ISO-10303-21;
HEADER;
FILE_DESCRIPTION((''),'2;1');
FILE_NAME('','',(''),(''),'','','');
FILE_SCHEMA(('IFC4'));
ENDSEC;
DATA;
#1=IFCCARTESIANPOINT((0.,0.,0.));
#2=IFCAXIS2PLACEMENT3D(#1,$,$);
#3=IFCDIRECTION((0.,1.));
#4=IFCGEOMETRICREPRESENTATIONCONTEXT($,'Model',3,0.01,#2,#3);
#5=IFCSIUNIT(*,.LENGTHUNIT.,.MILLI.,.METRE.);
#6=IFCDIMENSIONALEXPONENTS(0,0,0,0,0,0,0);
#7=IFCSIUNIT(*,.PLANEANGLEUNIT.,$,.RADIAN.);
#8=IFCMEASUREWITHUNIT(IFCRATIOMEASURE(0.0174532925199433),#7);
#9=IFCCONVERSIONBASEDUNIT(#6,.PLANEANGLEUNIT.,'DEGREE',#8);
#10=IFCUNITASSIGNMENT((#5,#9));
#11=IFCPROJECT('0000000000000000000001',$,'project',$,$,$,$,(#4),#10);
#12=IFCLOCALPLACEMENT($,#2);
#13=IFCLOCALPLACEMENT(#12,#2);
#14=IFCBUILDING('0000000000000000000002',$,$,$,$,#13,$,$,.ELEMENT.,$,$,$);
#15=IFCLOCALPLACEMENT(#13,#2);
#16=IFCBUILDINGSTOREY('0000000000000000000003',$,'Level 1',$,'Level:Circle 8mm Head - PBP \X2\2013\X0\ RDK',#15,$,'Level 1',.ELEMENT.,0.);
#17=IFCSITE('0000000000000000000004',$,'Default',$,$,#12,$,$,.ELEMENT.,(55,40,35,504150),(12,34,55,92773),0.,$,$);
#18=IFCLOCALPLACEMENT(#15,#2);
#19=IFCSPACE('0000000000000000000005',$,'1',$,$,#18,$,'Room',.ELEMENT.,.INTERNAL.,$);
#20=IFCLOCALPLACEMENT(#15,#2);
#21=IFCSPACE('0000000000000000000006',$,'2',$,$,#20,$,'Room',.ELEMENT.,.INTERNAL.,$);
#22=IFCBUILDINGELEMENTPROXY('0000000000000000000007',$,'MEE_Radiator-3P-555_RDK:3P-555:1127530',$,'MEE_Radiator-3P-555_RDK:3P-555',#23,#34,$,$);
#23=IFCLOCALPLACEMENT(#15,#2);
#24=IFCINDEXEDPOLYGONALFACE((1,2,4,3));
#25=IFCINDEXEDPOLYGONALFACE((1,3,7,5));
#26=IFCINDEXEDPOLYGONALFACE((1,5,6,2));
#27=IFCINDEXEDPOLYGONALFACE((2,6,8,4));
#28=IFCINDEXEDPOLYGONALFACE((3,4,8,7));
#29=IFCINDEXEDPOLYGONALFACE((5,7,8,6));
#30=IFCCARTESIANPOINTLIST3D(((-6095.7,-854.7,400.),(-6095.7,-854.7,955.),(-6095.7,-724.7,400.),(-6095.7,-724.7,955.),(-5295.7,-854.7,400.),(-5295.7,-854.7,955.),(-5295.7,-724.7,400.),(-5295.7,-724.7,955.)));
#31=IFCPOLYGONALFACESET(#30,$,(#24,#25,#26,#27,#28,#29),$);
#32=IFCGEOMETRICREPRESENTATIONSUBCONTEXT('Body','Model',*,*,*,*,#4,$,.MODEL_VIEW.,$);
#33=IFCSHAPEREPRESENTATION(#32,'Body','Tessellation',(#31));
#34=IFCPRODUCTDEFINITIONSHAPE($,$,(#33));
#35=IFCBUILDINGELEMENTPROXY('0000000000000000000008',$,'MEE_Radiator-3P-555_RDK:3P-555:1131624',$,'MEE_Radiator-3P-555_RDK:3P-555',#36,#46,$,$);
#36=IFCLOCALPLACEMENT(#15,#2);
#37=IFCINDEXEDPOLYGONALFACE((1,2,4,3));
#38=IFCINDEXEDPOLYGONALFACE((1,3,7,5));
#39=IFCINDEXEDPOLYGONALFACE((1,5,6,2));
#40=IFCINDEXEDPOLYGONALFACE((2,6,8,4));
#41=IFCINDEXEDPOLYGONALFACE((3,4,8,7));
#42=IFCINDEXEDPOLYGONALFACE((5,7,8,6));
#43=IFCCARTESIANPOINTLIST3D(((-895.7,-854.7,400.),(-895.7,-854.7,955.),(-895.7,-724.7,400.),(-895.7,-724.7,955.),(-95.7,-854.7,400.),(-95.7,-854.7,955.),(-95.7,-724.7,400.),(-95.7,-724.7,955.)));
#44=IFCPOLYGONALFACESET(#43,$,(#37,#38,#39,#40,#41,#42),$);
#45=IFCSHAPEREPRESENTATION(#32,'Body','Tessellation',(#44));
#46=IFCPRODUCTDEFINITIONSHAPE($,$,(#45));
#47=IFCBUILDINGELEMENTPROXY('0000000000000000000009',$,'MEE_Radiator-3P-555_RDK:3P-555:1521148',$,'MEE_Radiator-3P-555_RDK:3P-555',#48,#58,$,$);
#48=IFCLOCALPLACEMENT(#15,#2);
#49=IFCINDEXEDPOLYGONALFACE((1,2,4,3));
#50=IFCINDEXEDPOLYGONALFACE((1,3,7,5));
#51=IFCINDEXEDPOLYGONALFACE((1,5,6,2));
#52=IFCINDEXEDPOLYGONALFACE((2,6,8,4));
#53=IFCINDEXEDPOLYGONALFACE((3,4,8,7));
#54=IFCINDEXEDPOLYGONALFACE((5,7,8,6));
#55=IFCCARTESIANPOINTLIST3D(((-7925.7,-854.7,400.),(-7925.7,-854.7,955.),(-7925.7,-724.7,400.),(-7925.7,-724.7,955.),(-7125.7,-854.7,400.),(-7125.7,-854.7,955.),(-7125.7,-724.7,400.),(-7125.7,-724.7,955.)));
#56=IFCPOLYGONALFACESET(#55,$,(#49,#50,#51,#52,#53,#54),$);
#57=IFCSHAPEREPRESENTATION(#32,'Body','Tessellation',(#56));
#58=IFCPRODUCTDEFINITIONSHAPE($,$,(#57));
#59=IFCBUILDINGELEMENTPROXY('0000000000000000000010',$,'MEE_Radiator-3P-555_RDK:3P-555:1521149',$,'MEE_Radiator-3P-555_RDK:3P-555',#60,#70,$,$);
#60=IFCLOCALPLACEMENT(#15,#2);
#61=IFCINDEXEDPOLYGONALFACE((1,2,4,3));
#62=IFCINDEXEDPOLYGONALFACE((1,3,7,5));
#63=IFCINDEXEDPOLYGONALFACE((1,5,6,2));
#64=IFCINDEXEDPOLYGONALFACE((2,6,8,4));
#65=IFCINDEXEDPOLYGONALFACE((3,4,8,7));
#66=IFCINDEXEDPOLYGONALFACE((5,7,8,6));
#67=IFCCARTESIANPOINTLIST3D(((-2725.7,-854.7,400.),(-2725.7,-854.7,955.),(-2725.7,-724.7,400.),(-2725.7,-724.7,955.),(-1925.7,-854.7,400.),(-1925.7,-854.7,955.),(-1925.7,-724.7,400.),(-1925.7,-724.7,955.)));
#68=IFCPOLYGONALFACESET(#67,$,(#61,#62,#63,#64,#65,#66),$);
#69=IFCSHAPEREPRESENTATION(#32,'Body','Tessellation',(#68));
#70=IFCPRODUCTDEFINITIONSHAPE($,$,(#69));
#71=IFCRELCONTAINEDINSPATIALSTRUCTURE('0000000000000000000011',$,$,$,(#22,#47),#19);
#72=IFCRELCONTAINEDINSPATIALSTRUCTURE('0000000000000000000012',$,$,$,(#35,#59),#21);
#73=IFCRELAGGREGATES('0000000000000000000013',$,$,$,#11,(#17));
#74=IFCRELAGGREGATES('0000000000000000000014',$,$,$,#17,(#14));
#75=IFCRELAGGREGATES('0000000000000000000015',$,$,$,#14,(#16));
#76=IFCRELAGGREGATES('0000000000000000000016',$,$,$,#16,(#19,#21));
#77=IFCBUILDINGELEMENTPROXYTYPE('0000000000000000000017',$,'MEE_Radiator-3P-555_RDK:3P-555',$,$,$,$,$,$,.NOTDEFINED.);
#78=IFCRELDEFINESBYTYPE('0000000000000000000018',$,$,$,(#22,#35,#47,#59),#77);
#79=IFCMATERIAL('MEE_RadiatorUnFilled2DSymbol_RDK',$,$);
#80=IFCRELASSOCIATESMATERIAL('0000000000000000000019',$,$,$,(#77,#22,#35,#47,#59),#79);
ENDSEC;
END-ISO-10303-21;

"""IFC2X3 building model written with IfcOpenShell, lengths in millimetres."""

from ifc_helpers import new_model, entity, si_unit, converted_unit, direction, frame, origin, origin_2d_with_axis, place, context, subcontext, project, spatial, rectangle, extrude, source, transform, mapped, material, type_object, type_shapes, element, save


model = new_model("IFC2X3")

# Units and contexts
model_context = context("Model", 3, precision=0.01, world=origin(), true_north=direction((0.0, 1.0)))
body_context = subcontext(model_context, "Body", "Model", "MODEL_VIEW")
ifc_project = project(units=[si_unit("LENGTHUNIT", "METRE", prefix="MILLI"), converted_unit("PLANEANGLEUNIT", "DEGREE", entity("IfcRatioMeasure", 0.0174532925199433), si_unit("PLANEANGLEUNIT", "RADIAN"), dimensions=[0, 0, 0, 0, 0, 0, 0])], contexts=[model_context])

# Site, building, storey
site_placement = place(None, origin())
site = spatial("IfcSite", under=ifc_project, at=site_placement, Name="Default", CompositionType="ELEMENT", RefLatitude=(55, 40, 35, 504150), RefLongitude=(12, 34, 55, 92773), RefElevation=0.0)
building_placement = place(site_placement, origin())
building = spatial("IfcBuilding", under=site, at=building_placement, CompositionType="ELEMENT")
storey_placement = place(building_placement, origin())
storey = spatial("IfcBuildingStorey", under=building, at=storey_placement, Name="Level 1", ObjectType="Level:Circle 8mm Head - PBP – RDK", LongName="Level 1", CompositionType="ELEMENT", Elevation=0.0)

# Shared definitions
space_1_placement = place(storey_placement, origin())
space_1 = spatial("IfcSpace", under=storey, at=space_1_placement, Name="1", LongName="Room", CompositionType="ELEMENT", InteriorOrExteriorSpace="INTERNAL")

# Building element proxy
ifc_material_1 = material(Name="MEE_RadiatorUnFilled2DSymbol_RDK")
building_element_proxy_type_1 = type_object("IfcBuildingElementProxyType", Name="MEE_Radiator-3P-555_RDK:3P-555", PredefinedType="NOTDEFINED", material=ifc_material_1)
shared_shape_1 = source(origin(), body_context, "Body", "SweptSolid", [
    extrude(rectangle(XDim=800.0, YDim=130.0, at=origin_2d_with_axis()), frame((0.0, -65.0, 0.0), z_axis=(0.0, 0.0, 1.0), x_axis=(-1.0, 0.0, 0.0)), (0.0, 0.0, 1.0), 555.0),
])
type_shapes(building_element_proxy_type_1, [shared_shape_1])
proxy_1_placement = place(space_1_placement, frame((-5695.7, -854.7, 400.0), z_axis=(0.0, 0.0, 1.0), x_axis=(-1.0, 0.0, 0.0)))
element("IfcBuildingElementProxy", 1, at=proxy_1_placement, inside=space_1, type_object=building_element_proxy_type_1, material=ifc_material_1, Name="MEE_Radiator-3P-555_RDK:3P-555:1127530", ObjectType="MEE_Radiator-3P-555_RDK:3P-555", context=body_context, shape_type="MappedRepresentation", body=[
    mapped(shared_shape_1, transform((0.0, 0.0, 0.0), scale=1.0)),
])

# Shared definitions
space_2_placement = place(storey_placement, origin())
space_2 = spatial("IfcSpace", under=storey, at=space_2_placement, Name="2", LongName="Room", CompositionType="ELEMENT", InteriorOrExteriorSpace="INTERNAL")

# Building element proxies
proxy_2_placement = place(space_2_placement, frame((-495.7, -854.7, 400.0), z_axis=(0.0, 0.0, 1.0), x_axis=(-1.0, 0.0, 0.0)))
element("IfcBuildingElementProxy", 2, at=proxy_2_placement, inside=space_2, type_object=building_element_proxy_type_1, material=ifc_material_1, Name="MEE_Radiator-3P-555_RDK:3P-555:1131624", ObjectType="MEE_Radiator-3P-555_RDK:3P-555", context=body_context, shape_type="MappedRepresentation", body=[
    mapped(shared_shape_1, transform((0.0, 0.0, 0.0), scale=1.0)),
])
proxy_3_placement = place(space_1_placement, frame((-7525.7, -854.7, 400.0), z_axis=(0.0, 0.0, 1.0), x_axis=(-1.0, 0.0, 0.0)))
element("IfcBuildingElementProxy", 3, at=proxy_3_placement, inside=space_1, type_object=building_element_proxy_type_1, material=ifc_material_1, Name="MEE_Radiator-3P-555_RDK:3P-555:1521148", ObjectType="MEE_Radiator-3P-555_RDK:3P-555", context=body_context, shape_type="MappedRepresentation", body=[
    mapped(shared_shape_1, transform((0.0, 0.0, 0.0), scale=1.0)),
])
proxy_4_placement = place(space_2_placement, frame((-2325.7, -854.7, 400.0), z_axis=(0.0, 0.0, 1.0), x_axis=(-1.0, 0.0, 0.0)))
element("IfcBuildingElementProxy", 4, at=proxy_4_placement, inside=space_2, type_object=building_element_proxy_type_1, material=ifc_material_1, Name="MEE_Radiator-3P-555_RDK:3P-555:1521149", ObjectType="MEE_Radiator-3P-555_RDK:3P-555", context=body_context, shape_type="MappedRepresentation", body=[
    mapped(shared_shape_1, transform((0.0, 0.0, 0.0), scale=1.0)),
])

save(model, "model.ifc")
